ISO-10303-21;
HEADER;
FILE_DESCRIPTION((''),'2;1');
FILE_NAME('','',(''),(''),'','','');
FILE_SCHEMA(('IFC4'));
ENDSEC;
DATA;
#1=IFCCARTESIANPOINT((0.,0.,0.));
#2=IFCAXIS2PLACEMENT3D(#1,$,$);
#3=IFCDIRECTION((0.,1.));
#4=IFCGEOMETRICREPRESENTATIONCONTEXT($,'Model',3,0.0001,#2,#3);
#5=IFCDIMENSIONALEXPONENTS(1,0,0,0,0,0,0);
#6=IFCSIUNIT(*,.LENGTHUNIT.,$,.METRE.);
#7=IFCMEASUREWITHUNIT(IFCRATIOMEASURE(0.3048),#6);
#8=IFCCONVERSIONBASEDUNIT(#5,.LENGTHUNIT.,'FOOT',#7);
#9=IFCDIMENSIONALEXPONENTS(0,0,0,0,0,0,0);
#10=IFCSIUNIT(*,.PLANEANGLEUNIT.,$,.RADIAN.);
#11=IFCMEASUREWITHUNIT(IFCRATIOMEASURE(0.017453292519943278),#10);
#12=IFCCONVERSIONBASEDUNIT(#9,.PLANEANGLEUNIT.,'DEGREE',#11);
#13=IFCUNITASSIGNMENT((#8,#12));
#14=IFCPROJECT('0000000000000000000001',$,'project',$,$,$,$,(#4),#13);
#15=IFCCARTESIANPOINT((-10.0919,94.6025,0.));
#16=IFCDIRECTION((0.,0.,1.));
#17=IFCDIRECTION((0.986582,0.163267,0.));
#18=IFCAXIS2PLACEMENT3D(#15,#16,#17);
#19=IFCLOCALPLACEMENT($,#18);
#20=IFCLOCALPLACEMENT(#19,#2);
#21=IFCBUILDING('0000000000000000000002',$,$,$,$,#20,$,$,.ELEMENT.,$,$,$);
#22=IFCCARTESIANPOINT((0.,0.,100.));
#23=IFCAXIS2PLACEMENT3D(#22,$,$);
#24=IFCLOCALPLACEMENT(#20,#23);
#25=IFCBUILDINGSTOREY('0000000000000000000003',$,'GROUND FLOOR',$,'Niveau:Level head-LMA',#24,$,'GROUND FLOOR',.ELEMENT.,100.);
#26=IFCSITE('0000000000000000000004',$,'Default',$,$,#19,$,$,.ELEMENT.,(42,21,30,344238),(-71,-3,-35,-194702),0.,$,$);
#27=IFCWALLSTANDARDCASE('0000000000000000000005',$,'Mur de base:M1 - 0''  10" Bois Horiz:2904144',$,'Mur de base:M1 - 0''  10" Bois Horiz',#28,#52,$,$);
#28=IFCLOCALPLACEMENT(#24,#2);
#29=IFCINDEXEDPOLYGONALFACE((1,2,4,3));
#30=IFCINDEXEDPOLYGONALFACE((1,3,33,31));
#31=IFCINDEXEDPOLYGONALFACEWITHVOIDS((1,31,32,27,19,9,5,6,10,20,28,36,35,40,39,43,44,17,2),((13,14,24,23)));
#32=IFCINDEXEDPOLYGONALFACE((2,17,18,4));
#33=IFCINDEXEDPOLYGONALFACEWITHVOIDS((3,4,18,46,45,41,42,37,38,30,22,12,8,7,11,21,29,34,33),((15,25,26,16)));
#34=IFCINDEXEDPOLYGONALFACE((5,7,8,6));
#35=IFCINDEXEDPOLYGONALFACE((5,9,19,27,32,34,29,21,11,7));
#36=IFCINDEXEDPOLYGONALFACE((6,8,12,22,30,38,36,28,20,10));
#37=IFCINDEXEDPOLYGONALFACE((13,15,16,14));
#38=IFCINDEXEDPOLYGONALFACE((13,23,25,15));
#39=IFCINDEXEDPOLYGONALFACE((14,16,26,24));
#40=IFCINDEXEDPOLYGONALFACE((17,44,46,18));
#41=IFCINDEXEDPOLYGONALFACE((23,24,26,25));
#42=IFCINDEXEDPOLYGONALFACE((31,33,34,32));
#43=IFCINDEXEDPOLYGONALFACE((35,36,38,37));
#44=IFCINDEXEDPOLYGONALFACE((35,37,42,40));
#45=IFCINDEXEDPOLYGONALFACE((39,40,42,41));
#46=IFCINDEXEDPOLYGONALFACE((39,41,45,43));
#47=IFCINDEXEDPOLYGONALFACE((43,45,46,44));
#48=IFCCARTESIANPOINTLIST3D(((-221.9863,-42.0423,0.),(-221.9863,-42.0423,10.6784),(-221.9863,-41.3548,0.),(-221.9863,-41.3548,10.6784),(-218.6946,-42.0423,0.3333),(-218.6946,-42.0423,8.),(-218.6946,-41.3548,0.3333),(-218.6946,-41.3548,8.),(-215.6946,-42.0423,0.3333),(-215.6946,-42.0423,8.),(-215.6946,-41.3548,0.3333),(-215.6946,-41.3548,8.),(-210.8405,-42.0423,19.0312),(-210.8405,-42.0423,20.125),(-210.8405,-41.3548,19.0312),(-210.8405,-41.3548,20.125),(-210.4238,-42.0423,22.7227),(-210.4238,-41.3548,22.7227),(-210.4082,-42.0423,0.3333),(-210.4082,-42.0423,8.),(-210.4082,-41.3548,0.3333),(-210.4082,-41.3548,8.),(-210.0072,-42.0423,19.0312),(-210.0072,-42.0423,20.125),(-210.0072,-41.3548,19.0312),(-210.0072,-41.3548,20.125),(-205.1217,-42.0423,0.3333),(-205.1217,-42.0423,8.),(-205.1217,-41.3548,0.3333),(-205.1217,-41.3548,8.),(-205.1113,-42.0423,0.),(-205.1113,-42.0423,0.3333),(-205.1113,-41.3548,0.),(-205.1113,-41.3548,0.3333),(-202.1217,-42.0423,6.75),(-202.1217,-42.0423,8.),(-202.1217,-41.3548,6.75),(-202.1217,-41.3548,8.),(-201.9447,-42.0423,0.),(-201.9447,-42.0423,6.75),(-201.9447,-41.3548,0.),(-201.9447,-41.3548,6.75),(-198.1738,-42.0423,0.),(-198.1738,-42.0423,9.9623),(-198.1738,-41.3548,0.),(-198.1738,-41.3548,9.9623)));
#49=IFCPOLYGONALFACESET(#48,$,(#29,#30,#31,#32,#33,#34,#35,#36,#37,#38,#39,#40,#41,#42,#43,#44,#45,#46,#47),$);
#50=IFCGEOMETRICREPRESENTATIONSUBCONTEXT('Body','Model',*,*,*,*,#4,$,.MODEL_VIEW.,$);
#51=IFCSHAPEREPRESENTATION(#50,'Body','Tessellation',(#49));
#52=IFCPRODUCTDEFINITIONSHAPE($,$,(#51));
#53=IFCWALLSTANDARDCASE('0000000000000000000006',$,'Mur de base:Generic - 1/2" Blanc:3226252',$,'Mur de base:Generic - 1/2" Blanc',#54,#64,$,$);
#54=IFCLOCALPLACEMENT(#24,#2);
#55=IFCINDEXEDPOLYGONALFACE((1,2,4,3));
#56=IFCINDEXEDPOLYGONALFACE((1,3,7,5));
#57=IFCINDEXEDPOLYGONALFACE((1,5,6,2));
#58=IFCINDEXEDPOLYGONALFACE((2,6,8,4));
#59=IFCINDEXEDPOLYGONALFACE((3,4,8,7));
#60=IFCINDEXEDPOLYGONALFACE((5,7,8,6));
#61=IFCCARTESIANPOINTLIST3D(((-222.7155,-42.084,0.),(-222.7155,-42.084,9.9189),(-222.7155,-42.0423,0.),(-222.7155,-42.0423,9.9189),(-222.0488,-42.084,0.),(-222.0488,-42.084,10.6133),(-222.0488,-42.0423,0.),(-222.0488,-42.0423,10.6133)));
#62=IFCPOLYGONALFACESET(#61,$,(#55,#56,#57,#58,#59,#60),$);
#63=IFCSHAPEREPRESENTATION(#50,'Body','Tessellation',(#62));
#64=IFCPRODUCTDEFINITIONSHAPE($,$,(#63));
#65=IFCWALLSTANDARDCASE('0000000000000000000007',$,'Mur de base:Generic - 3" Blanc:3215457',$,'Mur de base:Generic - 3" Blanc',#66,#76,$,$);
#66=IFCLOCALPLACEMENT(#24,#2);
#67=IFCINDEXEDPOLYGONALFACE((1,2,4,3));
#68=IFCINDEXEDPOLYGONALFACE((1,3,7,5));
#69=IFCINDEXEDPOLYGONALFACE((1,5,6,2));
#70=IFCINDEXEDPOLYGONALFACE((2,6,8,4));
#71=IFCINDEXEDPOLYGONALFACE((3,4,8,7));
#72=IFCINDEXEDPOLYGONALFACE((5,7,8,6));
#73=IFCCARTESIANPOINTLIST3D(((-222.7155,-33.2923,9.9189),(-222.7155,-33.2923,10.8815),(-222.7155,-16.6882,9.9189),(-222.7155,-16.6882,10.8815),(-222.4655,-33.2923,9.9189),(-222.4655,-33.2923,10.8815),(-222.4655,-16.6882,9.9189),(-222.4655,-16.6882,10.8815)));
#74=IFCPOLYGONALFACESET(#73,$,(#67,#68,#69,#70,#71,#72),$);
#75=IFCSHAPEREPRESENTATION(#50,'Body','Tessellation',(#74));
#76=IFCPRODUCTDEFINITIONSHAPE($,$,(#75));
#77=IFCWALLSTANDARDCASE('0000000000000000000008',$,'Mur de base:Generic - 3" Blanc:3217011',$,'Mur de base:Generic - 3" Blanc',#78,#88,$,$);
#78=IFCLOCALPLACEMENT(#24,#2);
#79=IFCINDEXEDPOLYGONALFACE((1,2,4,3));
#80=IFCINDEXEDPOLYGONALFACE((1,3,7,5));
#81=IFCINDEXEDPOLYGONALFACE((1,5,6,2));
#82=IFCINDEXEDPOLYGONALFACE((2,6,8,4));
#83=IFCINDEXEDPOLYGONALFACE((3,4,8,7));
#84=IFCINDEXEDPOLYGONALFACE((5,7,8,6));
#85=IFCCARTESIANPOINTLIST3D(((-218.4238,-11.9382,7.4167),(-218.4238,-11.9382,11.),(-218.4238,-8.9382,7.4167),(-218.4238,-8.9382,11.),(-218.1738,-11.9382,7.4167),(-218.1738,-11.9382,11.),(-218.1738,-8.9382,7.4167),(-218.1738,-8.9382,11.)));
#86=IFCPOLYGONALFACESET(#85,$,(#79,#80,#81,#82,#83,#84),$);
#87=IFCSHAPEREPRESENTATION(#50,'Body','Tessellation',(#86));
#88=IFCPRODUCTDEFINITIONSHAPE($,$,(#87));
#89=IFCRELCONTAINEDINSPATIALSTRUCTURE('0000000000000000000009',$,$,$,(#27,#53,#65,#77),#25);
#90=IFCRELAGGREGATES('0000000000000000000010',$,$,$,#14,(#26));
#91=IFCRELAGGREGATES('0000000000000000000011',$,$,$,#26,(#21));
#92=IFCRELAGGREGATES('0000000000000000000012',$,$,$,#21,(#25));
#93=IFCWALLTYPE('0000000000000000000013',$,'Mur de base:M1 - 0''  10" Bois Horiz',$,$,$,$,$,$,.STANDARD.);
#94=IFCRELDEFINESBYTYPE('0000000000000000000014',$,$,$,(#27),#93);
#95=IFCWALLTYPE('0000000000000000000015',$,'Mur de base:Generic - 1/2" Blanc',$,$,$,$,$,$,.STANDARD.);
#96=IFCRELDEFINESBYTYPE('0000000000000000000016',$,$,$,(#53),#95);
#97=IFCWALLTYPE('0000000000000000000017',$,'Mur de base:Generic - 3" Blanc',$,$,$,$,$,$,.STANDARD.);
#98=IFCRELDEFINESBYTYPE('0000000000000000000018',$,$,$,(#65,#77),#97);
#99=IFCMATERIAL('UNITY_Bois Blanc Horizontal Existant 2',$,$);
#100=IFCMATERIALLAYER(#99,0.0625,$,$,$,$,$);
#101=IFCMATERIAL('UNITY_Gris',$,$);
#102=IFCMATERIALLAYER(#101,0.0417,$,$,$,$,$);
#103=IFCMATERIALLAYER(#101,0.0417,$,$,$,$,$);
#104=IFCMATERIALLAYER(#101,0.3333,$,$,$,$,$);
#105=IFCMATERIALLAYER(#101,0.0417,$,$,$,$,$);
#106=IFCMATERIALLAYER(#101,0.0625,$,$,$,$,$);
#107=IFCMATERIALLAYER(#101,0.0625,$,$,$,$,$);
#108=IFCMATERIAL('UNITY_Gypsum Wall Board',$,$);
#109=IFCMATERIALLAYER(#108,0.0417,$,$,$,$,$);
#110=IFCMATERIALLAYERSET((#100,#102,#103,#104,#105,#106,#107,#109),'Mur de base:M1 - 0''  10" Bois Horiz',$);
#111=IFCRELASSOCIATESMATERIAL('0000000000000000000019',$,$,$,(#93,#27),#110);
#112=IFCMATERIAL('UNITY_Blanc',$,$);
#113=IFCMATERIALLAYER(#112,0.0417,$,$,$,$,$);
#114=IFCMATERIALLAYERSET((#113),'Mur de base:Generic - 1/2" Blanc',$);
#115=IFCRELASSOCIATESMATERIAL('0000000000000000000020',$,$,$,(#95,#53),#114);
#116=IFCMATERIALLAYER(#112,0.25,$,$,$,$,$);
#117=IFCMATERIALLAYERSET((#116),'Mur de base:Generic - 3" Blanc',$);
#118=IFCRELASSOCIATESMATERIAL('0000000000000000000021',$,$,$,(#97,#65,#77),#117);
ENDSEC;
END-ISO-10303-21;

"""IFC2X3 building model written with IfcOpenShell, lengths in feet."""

from ifc_helpers import new_model, entity, si_unit, converted_unit, direction, frame, frame_2d, origin, place, context, subcontext, project, spatial, polyline, rectangle, extrude, clip, bounded_halfspace, material, layer, layer_set, layer_usage, type_object, element, save


model = new_model("IFC2X3")

# Units and contexts
model_context = context("Model", 3, precision=0.0001, world=origin(), true_north=direction((0.0, 1.0)))
body_context = subcontext(model_context, "Body", "Model", "MODEL_VIEW")
ifc_project = project(units=[converted_unit("LENGTHUNIT", "FOOT", entity("IfcRatioMeasure", 0.3048), si_unit("LENGTHUNIT", "METRE"), dimensions=[1, 0, 0, 0, 0, 0, 0]), converted_unit("PLANEANGLEUNIT", "DEGREE", entity("IfcRatioMeasure", 0.017453292519943278), si_unit("PLANEANGLEUNIT", "RADIAN"), dimensions=[0, 0, 0, 0, 0, 0, 0])], contexts=[model_context])

# Site, building, storey
site_placement = place(None, frame((-10.0919, 94.6025, 0.0), z_axis=(0.0, 0.0, 1.0), x_axis=(0.986582, 0.163267, 0.0)))
site = spatial("IfcSite", under=ifc_project, at=site_placement, Name="Default", CompositionType="ELEMENT", RefLatitude=(42, 21, 30, 344238), RefLongitude=(-71, -3, -35, -194702), RefElevation=0.0)
building_placement = place(site_placement, origin())
building = spatial("IfcBuilding", under=site, at=building_placement, CompositionType="ELEMENT")
storey_placement = place(building_placement, frame((0.0, 0.0, 100.0)))
storey = spatial("IfcBuildingStorey", under=building, at=storey_placement, Name="GROUND FLOOR", ObjectType="Niveau:Level head-LMA", LongName="GROUND FLOOR", CompositionType="ELEMENT", Elevation=100.0)

# Wall, openings
ifc_material_1 = material(Name="UNITY_Bois Blanc Horizontal Existant 2")
ifc_layer_1 = layer(ifc_material_1, 0.0625)
ifc_material_2 = material(Name="UNITY_Gris")
ifc_layer_2 = layer(ifc_material_2, 0.0417)
ifc_layer_3 = layer(ifc_material_2, 0.0417)
ifc_layer_4 = layer(ifc_material_2, 0.3333)
ifc_layer_5 = layer(ifc_material_2, 0.0417)
ifc_layer_6 = layer(ifc_material_2, 0.0625)
ifc_layer_7 = layer(ifc_material_2, 0.0625)
ifc_material_3 = material(Name="UNITY_Gypsum Wall Board")
ifc_layer_8 = layer(ifc_material_3, 0.0417)
ifc_layer_set_1 = layer_set([ifc_layer_1, ifc_layer_2, ifc_layer_3, ifc_layer_4, ifc_layer_5, ifc_layer_6, ifc_layer_7, ifc_layer_8], Name="Mur de base:M1 - 0'  10\" Bois Horiz")
ifc_layer_usage_1 = layer_usage(ifc_layer_set_1, "AXIS2", "POSITIVE", -0.3438)
wall_type_1 = type_object("IfcWallType", Name="Mur de base:M1 - 0'  10\" Bois Horiz", PredefinedType="STANDARD", material=ifc_layer_set_1)
wall_1_placement = place(storey_placement, frame((-221.9863, -41.6986, 0.0)))
wall_1 = element("IfcWallStandardCase", 1, at=wall_1_placement, inside=storey, type_object=wall_type_1, material=ifc_layer_usage_1, Name="Mur de base:M1 - 0'  10\" Bois Horiz:2904144", ObjectType="Mur de base:M1 - 0'  10\" Bois Horiz", context=body_context, shape_type="Clipping", body=[
    clip(clip(extrude(rectangle(XDim=23.8125, YDim=0.6875, at=frame_2d((11.9062, 0.0), x_axis=(-1.0, 0.0))), origin(), (0.0, 0.0, 1.0), 22.7227), bounded_halfspace(frame((0.0, -0.3438, 10.6784), z_axis=(-0.721387, 0.0, 0.692532), x_axis=(0.0, -1.0, 0.0)), False, frame((0.0, -0.3438, 10.6784)), polyline([(0.0, 0.0), (11.5625, 0.0), (11.5625, 0.6875), (0.0, 0.6875), (0.0, 0.0)]))), bounded_halfspace(frame((23.8125, -0.3438, 9.9623), z_axis=(0.721387, 0.0, 0.692532), x_axis=(0.0, 1.0, 0.0)), False, frame((23.8125, -0.3438, 9.9623)), polyline([(0.0, 0.0), (0.0, 0.6875), (-0.6875, 0.6875), (-12.25, 0.6875), (-12.25, 0.0), (0.0, 0.0)]))),
])
opening_1_placement = place(wall_1_placement, frame((221.9863, 41.6986, 0.0)))
element("IfcOpeningElement", 2, at=opening_1_placement, cuts=wall_1, ObjectType="Opening", context=body_context, shape_type="SweptSolid", body=[
    extrude(rectangle(XDim=6.75, YDim=3.1667, at=frame_2d((0.0, 0.0), x_axis=(0.0, 1.0))), frame((-203.528, -47.0423, 3.375), z_axis=(0.0, 1.0, 0.0), x_axis=(-1.0, 0.0, 0.0)), (0.0, 0.0, 1.0), 10.0),
])
opening_2_placement = place(wall_1_placement, frame((221.9863, 41.6986, 0.0)))
element("IfcOpeningElement", 3, at=opening_2_placement, cuts=wall_1, ObjectType="Opening", context=body_context, shape_type="SweptSolid", body=[
    extrude(rectangle(XDim=7.6667, YDim=5.2865, at=frame_2d((0.0, 0.0), x_axis=(0.0, 1.0))), frame((-207.765, -46.3548, 4.1667), z_axis=(0.0, 1.0, 0.0), x_axis=(-1.0, 0.0, 0.0)), (0.0, 0.0, 1.0), 10.0),
])
opening_3_placement = place(wall_1_placement, frame((221.9863, 41.6986, 0.0)))
element("IfcOpeningElement", 4, at=opening_3_placement, cuts=wall_1, ObjectType="Opening", context=body_context, shape_type="SweptSolid", body=[
    extrude(rectangle(XDim=7.6667, YDim=3.0, at=frame_2d((0.0, 0.0), x_axis=(0.0, 1.0))), frame((-203.6217, -46.3548, 4.1667), z_axis=(0.0, 1.0, 0.0), x_axis=(-1.0, 0.0, 0.0)), (0.0, 0.0, 1.0), 10.0),
])
opening_4_placement = place(wall_1_placement, frame((221.9863, 41.6986, 0.0)))
element("IfcOpeningElement", 5, at=opening_4_placement, cuts=wall_1, ObjectType="Opening", context=body_context, shape_type="SweptSolid", body=[
    extrude(rectangle(XDim=3.2708, YDim=5.125, at=frame_2d((0.0, 0.0), x_axis=(0.0, 1.0))), frame((-210.403, -46.3548, 5.6875), z_axis=(0.0, 1.0, 0.0), x_axis=(-1.0, 0.0, 0.0)), (0.0, 0.0, 1.0), 10.0),
])
opening_5_placement = place(wall_1_placement, frame((221.9863, 41.6986, 0.0)))
element("IfcOpeningElement", 6, at=opening_5_placement, cuts=wall_1, ObjectType="Opening", context=body_context, shape_type="SweptSolid", body=[
    extrude(rectangle(XDim=7.6667, YDim=5.2865, at=frame_2d((0.0, 0.0), x_axis=(0.0, 1.0))), frame((-213.0514, -46.3548, 4.1667), z_axis=(0.0, 1.0, 0.0), x_axis=(-1.0, 0.0, 0.0)), (0.0, 0.0, 1.0), 10.0),
])
opening_6_placement = place(wall_1_placement, frame((221.9863, 41.6986, 0.0)))
element("IfcOpeningElement", 7, at=opening_6_placement, cuts=wall_1, ObjectType="Opening", context=body_context, shape_type="SweptSolid", body=[
    extrude(rectangle(XDim=7.6667, YDim=3.0, at=frame_2d((0.0, 0.0), x_axis=(0.0, 1.0))), frame((-217.1946, -46.3548, 4.1667), z_axis=(0.0, 1.0, 0.0), x_axis=(-1.0, 0.0, 0.0)), (0.0, 0.0, 1.0), 10.0),
])
opening_7_placement = place(wall_1_placement, frame((221.9863, 41.6986, 10.3333)))
element("IfcOpeningElement", 8, at=opening_7_placement, cuts=wall_1, ObjectType="Opening", context=body_context, shape_type="SweptSolid", body=[
    extrude(rectangle(XDim=1.0938, YDim=0.8333, at=frame_2d((0.0, 0.0), x_axis=(0.0, 1.0))), frame((-210.4238, -46.3548, 9.2448), z_axis=(0.0, 1.0, 0.0), x_axis=(-1.0, 0.0, 0.0)), (0.0, 0.0, 1.0), 10.0),
])

# Wall
ifc_material_4 = material(Name="UNITY_Blanc")
ifc_layer_9 = layer(ifc_material_4, 0.0417)
ifc_layer_set_2 = layer_set([ifc_layer_9], Name="Mur de base:Generic - 1/2\" Blanc")
ifc_layer_usage_2 = layer_usage(ifc_layer_set_2, "AXIS2", "POSITIVE", -0.0208)
wall_type_2 = type_object("IfcWallType", Name="Mur de base:Generic - 1/2\" Blanc", PredefinedType="STANDARD", material=ifc_layer_set_2)
wall_2_placement = place(storey_placement, frame((-222.7155, -42.0632, 0.0)))
element("IfcWallStandardCase", 9, at=wall_2_placement, inside=storey, type_object=wall_type_2, material=ifc_layer_usage_2, Name="Mur de base:Generic - 1/2\" Blanc:3226252", ObjectType="Mur de base:Generic - 1/2\" Blanc", context=body_context, shape_type="Clipping", body=[
    clip(extrude(rectangle(XDim=0.6667, YDim=0.0417, at=frame_2d((0.3333, 0.0), x_axis=(-1.0, 0.0))), origin(), (0.0, 0.0, 1.0), 10.6133), bounded_halfspace(frame((0.0, -0.0208, 9.9189), z_axis=(-0.721387, 0.0, 0.692532), x_axis=(0.0, -1.0, 0.0)), False, frame((0.0, -0.0208, 9.9189)), polyline([(0.0, 0.0), (0.6667, 0.0), (0.6667, 0.0417), (0.0417, 0.0417), (0.0, 0.0417), (0.0, 0.0)]))),
])

# Shared definitions
ifc_layer_10 = layer(ifc_material_4, 0.25)
ifc_layer_set_3 = layer_set([ifc_layer_10], Name="Mur de base:Generic - 3\" Blanc")
wall_type_3 = type_object("IfcWallType", Name="Mur de base:Generic - 3\" Blanc", PredefinedType="STANDARD", material=ifc_layer_set_3)

# Walls
ifc_layer_usage_3 = layer_usage(ifc_layer_set_3, "AXIS2", "POSITIVE", -0.125)
wall_3_placement = place(storey_placement, frame((-222.5905, -16.6882, 9.9189), z_axis=(0.0, 0.0, 1.0), x_axis=(0.0, -1.0, 0.0)))
element("IfcWallStandardCase", 10, at=wall_3_placement, inside=storey, type_object=wall_type_3, material=ifc_layer_usage_3, Name="Mur de base:Generic - 3\" Blanc:3215457", ObjectType="Mur de base:Generic - 3\" Blanc", context=body_context, shape_type="SweptSolid", body=[
    extrude(rectangle(XDim=16.6042, YDim=0.25, at=frame_2d((8.3021, 0.0), x_axis=(-1.0, 0.0))), origin(), (0.0, 0.0, 1.0), 0.9627),
])
ifc_layer_usage_4 = layer_usage(ifc_layer_set_3, "AXIS2", "POSITIVE", -0.125)
wall_4_placement = place(storey_placement, frame((-218.2988, -11.9382, 7.4167), z_axis=(0.0, 0.0, 1.0), x_axis=(0.0, 1.0, 0.0)))
element("IfcWallStandardCase", 11, at=wall_4_placement, inside=storey, type_object=wall_type_3, material=ifc_layer_usage_4, Name="Mur de base:Generic - 3\" Blanc:3217011", ObjectType="Mur de base:Generic - 3\" Blanc", context=body_context, shape_type="SweptSolid", body=[
    extrude(rectangle(XDim=3.0, YDim=0.25, at=frame_2d((1.5, 0.0), x_axis=(-1.0, 0.0))), origin(), (0.0, 0.0, 1.0), 3.5833),
])

save(model, "model.ifc")
